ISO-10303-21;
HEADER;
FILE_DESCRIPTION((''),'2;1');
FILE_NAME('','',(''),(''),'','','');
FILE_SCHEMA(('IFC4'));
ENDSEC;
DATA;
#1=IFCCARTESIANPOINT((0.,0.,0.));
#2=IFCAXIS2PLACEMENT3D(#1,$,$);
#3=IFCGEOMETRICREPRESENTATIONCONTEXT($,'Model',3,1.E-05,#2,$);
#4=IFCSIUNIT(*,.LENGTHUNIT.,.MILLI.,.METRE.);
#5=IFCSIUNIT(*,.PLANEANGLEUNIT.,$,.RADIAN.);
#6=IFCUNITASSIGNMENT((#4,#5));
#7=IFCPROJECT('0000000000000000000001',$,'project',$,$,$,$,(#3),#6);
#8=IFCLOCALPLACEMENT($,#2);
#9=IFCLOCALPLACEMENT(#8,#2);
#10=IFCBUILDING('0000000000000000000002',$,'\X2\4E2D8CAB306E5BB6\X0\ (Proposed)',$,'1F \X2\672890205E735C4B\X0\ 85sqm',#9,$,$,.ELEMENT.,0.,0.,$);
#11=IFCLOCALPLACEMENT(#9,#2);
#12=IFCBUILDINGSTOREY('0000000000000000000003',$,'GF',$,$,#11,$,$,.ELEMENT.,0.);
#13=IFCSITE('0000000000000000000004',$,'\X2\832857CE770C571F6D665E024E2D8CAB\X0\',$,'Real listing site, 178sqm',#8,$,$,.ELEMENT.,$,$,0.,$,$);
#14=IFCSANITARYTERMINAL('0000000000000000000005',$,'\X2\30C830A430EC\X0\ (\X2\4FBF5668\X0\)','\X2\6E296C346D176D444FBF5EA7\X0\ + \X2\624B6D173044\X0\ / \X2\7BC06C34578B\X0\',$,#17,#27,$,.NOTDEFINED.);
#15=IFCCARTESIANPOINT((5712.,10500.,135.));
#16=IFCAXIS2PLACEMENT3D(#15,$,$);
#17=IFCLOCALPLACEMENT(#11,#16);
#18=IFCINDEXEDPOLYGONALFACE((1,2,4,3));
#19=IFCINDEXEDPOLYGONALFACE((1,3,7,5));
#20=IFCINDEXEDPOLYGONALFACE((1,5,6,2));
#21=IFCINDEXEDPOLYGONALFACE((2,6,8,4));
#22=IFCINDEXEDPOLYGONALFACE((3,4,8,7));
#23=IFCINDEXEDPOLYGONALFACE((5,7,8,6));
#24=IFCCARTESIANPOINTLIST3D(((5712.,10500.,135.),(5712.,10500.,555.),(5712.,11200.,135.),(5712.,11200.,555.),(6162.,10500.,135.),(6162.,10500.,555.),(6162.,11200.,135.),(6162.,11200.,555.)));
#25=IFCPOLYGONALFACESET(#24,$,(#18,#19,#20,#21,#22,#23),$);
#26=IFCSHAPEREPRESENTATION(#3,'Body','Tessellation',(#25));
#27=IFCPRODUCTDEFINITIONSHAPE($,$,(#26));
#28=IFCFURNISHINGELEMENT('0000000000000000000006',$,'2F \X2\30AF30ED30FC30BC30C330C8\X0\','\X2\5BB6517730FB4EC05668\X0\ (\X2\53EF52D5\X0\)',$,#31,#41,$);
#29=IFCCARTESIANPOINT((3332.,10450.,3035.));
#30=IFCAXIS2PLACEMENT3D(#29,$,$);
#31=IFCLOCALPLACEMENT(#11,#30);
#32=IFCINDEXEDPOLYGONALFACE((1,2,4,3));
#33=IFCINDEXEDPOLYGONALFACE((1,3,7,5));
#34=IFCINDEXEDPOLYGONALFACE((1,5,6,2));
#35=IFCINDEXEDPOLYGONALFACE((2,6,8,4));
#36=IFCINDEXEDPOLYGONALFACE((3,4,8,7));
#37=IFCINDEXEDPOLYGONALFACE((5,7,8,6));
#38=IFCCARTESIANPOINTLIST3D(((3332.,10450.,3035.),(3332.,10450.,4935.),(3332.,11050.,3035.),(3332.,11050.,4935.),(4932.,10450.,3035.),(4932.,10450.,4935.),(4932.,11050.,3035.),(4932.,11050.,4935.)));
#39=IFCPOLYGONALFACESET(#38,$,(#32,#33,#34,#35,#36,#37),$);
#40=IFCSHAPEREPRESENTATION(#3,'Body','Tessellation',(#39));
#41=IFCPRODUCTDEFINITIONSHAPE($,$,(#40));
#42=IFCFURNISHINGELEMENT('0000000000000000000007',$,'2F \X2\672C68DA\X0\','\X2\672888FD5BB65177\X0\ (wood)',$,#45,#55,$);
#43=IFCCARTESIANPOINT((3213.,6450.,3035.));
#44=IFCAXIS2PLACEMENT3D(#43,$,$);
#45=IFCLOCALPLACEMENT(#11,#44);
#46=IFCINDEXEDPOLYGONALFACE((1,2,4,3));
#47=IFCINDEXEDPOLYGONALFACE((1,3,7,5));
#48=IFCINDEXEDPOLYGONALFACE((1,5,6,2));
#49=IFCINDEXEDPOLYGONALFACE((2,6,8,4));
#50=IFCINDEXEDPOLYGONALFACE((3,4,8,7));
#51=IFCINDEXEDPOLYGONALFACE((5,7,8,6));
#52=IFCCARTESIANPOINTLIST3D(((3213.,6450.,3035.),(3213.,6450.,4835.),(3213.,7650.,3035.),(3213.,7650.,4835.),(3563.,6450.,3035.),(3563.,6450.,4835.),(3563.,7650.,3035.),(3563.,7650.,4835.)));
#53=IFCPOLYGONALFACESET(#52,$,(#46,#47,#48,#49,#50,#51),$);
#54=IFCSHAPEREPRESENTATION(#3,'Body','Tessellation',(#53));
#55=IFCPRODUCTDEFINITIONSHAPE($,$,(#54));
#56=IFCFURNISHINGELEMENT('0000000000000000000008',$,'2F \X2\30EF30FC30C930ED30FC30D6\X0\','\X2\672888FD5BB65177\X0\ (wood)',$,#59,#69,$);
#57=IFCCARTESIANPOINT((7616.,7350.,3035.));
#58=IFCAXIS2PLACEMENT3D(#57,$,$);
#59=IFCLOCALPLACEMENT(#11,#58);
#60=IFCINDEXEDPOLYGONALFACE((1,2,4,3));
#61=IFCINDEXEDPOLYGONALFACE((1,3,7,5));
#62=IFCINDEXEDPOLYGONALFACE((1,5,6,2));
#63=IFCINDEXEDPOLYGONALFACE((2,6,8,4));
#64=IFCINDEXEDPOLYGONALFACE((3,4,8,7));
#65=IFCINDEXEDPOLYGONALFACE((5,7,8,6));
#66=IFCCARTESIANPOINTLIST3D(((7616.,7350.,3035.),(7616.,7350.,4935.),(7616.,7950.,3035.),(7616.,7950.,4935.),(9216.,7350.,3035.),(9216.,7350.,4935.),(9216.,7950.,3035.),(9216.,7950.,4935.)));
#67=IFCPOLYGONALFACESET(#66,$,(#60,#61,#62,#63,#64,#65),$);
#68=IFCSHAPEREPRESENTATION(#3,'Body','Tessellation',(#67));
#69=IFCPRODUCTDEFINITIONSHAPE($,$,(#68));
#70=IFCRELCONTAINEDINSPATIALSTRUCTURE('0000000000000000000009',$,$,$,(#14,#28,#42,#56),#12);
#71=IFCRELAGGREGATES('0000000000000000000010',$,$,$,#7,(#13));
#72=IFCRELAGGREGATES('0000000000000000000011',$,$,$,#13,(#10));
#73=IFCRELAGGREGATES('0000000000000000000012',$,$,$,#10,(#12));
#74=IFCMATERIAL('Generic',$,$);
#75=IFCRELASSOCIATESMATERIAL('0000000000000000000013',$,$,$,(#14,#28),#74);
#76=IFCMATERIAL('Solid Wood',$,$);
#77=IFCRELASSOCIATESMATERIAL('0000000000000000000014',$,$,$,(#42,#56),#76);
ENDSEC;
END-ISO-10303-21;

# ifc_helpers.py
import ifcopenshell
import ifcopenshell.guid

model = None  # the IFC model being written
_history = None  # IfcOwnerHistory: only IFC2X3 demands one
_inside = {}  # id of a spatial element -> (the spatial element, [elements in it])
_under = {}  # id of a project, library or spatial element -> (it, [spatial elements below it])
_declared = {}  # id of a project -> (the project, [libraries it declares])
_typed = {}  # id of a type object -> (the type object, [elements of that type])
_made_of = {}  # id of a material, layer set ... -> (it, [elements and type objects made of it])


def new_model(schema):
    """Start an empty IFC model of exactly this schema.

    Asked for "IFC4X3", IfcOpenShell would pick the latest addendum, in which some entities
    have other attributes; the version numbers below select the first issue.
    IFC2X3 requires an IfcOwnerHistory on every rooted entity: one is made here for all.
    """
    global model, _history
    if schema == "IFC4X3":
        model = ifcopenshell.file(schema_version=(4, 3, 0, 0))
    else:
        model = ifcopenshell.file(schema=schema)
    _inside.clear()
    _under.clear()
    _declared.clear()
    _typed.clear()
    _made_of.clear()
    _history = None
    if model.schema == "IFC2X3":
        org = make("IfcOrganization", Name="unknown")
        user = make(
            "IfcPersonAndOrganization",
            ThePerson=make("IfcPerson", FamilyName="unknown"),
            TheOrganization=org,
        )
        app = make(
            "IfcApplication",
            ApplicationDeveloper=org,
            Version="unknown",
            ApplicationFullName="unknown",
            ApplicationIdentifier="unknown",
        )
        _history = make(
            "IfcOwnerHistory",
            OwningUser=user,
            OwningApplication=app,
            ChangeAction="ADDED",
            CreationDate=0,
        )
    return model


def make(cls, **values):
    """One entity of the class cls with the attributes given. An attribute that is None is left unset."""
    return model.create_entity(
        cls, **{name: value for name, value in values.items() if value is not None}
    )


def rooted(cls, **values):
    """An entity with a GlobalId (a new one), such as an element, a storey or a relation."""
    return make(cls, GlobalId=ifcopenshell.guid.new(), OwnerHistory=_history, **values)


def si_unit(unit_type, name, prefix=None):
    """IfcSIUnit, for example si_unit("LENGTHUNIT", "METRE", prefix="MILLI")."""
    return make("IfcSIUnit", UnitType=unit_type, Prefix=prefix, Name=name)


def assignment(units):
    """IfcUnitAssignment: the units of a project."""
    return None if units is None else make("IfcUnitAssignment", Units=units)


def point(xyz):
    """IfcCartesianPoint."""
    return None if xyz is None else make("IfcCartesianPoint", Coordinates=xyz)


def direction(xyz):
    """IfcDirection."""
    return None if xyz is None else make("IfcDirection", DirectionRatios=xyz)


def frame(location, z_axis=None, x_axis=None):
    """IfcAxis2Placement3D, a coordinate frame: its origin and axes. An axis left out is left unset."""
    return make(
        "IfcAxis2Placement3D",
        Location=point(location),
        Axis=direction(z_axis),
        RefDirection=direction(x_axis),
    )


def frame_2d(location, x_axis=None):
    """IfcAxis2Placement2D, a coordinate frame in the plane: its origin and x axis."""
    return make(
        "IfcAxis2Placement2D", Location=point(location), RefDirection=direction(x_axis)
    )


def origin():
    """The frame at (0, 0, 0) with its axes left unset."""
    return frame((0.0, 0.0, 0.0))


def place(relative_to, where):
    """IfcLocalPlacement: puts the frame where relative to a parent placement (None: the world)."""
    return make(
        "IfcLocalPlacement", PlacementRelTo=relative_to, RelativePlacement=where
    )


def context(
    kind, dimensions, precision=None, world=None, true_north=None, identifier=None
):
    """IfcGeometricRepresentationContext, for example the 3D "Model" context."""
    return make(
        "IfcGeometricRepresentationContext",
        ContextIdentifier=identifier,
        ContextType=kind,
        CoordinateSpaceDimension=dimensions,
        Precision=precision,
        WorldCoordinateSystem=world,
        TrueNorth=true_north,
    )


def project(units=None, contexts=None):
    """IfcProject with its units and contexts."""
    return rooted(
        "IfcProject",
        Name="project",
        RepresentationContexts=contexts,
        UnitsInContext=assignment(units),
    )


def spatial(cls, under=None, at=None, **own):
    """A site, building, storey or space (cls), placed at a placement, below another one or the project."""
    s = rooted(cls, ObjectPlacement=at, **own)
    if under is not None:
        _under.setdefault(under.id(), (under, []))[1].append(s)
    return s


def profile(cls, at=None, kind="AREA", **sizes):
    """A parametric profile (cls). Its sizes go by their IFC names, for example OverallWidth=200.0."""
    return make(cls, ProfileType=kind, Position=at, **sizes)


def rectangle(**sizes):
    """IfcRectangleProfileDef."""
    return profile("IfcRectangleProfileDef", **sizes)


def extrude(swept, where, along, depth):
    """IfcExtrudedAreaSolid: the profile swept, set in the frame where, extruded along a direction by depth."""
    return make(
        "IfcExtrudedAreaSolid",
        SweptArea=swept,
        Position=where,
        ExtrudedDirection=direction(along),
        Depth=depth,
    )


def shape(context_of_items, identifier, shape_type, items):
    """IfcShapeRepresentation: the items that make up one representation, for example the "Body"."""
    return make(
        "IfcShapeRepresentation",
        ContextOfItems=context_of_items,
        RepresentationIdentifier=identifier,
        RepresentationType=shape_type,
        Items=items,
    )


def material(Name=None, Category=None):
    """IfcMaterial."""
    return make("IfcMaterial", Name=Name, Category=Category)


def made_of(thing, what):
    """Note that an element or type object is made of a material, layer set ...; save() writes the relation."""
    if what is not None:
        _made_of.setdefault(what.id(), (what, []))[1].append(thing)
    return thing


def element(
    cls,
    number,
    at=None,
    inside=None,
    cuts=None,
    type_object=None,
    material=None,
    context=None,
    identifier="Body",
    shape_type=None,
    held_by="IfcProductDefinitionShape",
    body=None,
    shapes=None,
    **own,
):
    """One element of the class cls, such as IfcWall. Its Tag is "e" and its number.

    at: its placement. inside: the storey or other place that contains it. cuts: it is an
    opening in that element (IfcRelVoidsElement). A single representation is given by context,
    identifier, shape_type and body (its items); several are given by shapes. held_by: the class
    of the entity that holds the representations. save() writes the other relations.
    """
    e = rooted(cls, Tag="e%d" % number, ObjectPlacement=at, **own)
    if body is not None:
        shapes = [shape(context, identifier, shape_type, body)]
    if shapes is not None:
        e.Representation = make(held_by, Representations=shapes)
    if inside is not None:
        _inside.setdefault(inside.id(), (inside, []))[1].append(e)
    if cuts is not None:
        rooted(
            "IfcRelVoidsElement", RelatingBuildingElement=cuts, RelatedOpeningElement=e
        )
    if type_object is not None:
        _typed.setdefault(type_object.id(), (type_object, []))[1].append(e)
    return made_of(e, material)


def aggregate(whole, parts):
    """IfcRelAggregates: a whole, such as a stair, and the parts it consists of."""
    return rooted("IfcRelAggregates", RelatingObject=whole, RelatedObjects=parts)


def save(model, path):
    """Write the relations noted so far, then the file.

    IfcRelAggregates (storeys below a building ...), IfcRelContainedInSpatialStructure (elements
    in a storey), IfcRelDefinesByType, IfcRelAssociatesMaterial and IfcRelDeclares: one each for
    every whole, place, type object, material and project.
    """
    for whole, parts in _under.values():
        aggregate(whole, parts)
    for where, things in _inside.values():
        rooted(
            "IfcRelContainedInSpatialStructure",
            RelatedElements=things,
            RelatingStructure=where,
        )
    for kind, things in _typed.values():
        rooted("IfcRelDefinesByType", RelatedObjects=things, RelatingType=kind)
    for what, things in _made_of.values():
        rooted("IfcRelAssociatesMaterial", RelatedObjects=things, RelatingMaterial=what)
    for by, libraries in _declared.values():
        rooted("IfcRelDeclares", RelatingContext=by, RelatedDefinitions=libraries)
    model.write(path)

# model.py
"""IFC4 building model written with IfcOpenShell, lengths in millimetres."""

from ifc_helpers import new_model, si_unit, frame, frame_2d, origin, place, context, project, spatial, rectangle, extrude, material, element, save


model = new_model("IFC4")

# Units and contexts
model_context = context("Model", 3, precision=1e-05, world=origin())
ifc_project = project(units=[si_unit("LENGTHUNIT", "METRE", prefix="MILLI"), si_unit("PLANEANGLEUNIT", "RADIAN")], contexts=[model_context])

# Site, building, storey
site_placement = place(None, origin())
site = spatial("IfcSite", under=ifc_project, at=site_placement, Name="茨城県土浦市中貫", ObjectType="Real listing site, 178sqm", CompositionType="ELEMENT", RefElevation=0.0)
building_placement = place(site_placement, origin())
building = spatial("IfcBuilding", under=site, at=building_placement, Name="中貫の家 (Proposed)", ObjectType="1F 木造平屋 85sqm", CompositionType="ELEMENT", ElevationOfRefHeight=0.0, ElevationOfTerrain=0.0)
storey_placement = place(building_placement, origin())
storey = spatial("IfcBuildingStorey", under=building, at=storey_placement, Name="GF", CompositionType="ELEMENT", Elevation=0.0)

# Shared definitions
ifc_material_1 = material(Name="Solid Wood")

# Shared definitions
ifc_material_2 = material(Name="Generic")

# Sanitary terminal
sanitary_terminal_placement = place(storey_placement, frame((5712.0, 10500.0, 135.0)))
element("IfcSanitaryTerminal", 1, at=sanitary_terminal_placement, inside=storey, material=ifc_material_2, Name="トイレ (便器)", Description="温水洗浄便座 + 手洗い / 節水型", PredefinedType="NOTDEFINED", context=model_context, shape_type="SweptSolid", body=[
    extrude(rectangle(XDim=450.0, YDim=700.0, at=frame_2d((225.0, 350.0))), frame((5712.0, 10500.0, 135.0)), (0.0, 0.0, 1.0), 420.0),
])

# Furnishing elements
furnishing_1_placement = place(storey_placement, frame((3332.0, 10450.0, 3035.0)))
element("IfcFurnishingElement", 2, at=furnishing_1_placement, inside=storey, material=ifc_material_2, Name="2F クローゼット", Description="家具・什器 (可動)", context=model_context, shape_type="SweptSolid", body=[
    extrude(rectangle(XDim=1600.0, YDim=600.0, at=frame_2d((800.0, 300.0))), frame((3332.0, 10450.0, 3035.0)), (0.0, 0.0, 1.0), 1900.0),
])
furnishing_2_placement = place(storey_placement, frame((3213.0, 6450.0, 3035.0)))
element("IfcFurnishingElement", 3, at=furnishing_2_placement, inside=storey, material=ifc_material_1, Name="2F 本棚", Description="木製家具 (wood)", context=model_context, shape_type="SweptSolid", body=[
    extrude(rectangle(XDim=350.0, YDim=1200.0, at=frame_2d((175.0, 600.0))), frame((3213.0, 6450.0, 3035.0)), (0.0, 0.0, 1.0), 1800.0),
])
furnishing_3_placement = place(storey_placement, frame((7616.0, 7350.0, 3035.0)))
element("IfcFurnishingElement", 4, at=furnishing_3_placement, inside=storey, material=ifc_material_1, Name="2F ワードローブ", Description="木製家具 (wood)", context=model_context, shape_type="SweptSolid", body=[
    extrude(rectangle(XDim=1600.0, YDim=600.0, at=frame_2d((800.0, 300.0))), frame((7616.0, 7350.0, 3035.0)), (0.0, 0.0, 1.0), 1900.0),
])

save(model, "model.ifc")
